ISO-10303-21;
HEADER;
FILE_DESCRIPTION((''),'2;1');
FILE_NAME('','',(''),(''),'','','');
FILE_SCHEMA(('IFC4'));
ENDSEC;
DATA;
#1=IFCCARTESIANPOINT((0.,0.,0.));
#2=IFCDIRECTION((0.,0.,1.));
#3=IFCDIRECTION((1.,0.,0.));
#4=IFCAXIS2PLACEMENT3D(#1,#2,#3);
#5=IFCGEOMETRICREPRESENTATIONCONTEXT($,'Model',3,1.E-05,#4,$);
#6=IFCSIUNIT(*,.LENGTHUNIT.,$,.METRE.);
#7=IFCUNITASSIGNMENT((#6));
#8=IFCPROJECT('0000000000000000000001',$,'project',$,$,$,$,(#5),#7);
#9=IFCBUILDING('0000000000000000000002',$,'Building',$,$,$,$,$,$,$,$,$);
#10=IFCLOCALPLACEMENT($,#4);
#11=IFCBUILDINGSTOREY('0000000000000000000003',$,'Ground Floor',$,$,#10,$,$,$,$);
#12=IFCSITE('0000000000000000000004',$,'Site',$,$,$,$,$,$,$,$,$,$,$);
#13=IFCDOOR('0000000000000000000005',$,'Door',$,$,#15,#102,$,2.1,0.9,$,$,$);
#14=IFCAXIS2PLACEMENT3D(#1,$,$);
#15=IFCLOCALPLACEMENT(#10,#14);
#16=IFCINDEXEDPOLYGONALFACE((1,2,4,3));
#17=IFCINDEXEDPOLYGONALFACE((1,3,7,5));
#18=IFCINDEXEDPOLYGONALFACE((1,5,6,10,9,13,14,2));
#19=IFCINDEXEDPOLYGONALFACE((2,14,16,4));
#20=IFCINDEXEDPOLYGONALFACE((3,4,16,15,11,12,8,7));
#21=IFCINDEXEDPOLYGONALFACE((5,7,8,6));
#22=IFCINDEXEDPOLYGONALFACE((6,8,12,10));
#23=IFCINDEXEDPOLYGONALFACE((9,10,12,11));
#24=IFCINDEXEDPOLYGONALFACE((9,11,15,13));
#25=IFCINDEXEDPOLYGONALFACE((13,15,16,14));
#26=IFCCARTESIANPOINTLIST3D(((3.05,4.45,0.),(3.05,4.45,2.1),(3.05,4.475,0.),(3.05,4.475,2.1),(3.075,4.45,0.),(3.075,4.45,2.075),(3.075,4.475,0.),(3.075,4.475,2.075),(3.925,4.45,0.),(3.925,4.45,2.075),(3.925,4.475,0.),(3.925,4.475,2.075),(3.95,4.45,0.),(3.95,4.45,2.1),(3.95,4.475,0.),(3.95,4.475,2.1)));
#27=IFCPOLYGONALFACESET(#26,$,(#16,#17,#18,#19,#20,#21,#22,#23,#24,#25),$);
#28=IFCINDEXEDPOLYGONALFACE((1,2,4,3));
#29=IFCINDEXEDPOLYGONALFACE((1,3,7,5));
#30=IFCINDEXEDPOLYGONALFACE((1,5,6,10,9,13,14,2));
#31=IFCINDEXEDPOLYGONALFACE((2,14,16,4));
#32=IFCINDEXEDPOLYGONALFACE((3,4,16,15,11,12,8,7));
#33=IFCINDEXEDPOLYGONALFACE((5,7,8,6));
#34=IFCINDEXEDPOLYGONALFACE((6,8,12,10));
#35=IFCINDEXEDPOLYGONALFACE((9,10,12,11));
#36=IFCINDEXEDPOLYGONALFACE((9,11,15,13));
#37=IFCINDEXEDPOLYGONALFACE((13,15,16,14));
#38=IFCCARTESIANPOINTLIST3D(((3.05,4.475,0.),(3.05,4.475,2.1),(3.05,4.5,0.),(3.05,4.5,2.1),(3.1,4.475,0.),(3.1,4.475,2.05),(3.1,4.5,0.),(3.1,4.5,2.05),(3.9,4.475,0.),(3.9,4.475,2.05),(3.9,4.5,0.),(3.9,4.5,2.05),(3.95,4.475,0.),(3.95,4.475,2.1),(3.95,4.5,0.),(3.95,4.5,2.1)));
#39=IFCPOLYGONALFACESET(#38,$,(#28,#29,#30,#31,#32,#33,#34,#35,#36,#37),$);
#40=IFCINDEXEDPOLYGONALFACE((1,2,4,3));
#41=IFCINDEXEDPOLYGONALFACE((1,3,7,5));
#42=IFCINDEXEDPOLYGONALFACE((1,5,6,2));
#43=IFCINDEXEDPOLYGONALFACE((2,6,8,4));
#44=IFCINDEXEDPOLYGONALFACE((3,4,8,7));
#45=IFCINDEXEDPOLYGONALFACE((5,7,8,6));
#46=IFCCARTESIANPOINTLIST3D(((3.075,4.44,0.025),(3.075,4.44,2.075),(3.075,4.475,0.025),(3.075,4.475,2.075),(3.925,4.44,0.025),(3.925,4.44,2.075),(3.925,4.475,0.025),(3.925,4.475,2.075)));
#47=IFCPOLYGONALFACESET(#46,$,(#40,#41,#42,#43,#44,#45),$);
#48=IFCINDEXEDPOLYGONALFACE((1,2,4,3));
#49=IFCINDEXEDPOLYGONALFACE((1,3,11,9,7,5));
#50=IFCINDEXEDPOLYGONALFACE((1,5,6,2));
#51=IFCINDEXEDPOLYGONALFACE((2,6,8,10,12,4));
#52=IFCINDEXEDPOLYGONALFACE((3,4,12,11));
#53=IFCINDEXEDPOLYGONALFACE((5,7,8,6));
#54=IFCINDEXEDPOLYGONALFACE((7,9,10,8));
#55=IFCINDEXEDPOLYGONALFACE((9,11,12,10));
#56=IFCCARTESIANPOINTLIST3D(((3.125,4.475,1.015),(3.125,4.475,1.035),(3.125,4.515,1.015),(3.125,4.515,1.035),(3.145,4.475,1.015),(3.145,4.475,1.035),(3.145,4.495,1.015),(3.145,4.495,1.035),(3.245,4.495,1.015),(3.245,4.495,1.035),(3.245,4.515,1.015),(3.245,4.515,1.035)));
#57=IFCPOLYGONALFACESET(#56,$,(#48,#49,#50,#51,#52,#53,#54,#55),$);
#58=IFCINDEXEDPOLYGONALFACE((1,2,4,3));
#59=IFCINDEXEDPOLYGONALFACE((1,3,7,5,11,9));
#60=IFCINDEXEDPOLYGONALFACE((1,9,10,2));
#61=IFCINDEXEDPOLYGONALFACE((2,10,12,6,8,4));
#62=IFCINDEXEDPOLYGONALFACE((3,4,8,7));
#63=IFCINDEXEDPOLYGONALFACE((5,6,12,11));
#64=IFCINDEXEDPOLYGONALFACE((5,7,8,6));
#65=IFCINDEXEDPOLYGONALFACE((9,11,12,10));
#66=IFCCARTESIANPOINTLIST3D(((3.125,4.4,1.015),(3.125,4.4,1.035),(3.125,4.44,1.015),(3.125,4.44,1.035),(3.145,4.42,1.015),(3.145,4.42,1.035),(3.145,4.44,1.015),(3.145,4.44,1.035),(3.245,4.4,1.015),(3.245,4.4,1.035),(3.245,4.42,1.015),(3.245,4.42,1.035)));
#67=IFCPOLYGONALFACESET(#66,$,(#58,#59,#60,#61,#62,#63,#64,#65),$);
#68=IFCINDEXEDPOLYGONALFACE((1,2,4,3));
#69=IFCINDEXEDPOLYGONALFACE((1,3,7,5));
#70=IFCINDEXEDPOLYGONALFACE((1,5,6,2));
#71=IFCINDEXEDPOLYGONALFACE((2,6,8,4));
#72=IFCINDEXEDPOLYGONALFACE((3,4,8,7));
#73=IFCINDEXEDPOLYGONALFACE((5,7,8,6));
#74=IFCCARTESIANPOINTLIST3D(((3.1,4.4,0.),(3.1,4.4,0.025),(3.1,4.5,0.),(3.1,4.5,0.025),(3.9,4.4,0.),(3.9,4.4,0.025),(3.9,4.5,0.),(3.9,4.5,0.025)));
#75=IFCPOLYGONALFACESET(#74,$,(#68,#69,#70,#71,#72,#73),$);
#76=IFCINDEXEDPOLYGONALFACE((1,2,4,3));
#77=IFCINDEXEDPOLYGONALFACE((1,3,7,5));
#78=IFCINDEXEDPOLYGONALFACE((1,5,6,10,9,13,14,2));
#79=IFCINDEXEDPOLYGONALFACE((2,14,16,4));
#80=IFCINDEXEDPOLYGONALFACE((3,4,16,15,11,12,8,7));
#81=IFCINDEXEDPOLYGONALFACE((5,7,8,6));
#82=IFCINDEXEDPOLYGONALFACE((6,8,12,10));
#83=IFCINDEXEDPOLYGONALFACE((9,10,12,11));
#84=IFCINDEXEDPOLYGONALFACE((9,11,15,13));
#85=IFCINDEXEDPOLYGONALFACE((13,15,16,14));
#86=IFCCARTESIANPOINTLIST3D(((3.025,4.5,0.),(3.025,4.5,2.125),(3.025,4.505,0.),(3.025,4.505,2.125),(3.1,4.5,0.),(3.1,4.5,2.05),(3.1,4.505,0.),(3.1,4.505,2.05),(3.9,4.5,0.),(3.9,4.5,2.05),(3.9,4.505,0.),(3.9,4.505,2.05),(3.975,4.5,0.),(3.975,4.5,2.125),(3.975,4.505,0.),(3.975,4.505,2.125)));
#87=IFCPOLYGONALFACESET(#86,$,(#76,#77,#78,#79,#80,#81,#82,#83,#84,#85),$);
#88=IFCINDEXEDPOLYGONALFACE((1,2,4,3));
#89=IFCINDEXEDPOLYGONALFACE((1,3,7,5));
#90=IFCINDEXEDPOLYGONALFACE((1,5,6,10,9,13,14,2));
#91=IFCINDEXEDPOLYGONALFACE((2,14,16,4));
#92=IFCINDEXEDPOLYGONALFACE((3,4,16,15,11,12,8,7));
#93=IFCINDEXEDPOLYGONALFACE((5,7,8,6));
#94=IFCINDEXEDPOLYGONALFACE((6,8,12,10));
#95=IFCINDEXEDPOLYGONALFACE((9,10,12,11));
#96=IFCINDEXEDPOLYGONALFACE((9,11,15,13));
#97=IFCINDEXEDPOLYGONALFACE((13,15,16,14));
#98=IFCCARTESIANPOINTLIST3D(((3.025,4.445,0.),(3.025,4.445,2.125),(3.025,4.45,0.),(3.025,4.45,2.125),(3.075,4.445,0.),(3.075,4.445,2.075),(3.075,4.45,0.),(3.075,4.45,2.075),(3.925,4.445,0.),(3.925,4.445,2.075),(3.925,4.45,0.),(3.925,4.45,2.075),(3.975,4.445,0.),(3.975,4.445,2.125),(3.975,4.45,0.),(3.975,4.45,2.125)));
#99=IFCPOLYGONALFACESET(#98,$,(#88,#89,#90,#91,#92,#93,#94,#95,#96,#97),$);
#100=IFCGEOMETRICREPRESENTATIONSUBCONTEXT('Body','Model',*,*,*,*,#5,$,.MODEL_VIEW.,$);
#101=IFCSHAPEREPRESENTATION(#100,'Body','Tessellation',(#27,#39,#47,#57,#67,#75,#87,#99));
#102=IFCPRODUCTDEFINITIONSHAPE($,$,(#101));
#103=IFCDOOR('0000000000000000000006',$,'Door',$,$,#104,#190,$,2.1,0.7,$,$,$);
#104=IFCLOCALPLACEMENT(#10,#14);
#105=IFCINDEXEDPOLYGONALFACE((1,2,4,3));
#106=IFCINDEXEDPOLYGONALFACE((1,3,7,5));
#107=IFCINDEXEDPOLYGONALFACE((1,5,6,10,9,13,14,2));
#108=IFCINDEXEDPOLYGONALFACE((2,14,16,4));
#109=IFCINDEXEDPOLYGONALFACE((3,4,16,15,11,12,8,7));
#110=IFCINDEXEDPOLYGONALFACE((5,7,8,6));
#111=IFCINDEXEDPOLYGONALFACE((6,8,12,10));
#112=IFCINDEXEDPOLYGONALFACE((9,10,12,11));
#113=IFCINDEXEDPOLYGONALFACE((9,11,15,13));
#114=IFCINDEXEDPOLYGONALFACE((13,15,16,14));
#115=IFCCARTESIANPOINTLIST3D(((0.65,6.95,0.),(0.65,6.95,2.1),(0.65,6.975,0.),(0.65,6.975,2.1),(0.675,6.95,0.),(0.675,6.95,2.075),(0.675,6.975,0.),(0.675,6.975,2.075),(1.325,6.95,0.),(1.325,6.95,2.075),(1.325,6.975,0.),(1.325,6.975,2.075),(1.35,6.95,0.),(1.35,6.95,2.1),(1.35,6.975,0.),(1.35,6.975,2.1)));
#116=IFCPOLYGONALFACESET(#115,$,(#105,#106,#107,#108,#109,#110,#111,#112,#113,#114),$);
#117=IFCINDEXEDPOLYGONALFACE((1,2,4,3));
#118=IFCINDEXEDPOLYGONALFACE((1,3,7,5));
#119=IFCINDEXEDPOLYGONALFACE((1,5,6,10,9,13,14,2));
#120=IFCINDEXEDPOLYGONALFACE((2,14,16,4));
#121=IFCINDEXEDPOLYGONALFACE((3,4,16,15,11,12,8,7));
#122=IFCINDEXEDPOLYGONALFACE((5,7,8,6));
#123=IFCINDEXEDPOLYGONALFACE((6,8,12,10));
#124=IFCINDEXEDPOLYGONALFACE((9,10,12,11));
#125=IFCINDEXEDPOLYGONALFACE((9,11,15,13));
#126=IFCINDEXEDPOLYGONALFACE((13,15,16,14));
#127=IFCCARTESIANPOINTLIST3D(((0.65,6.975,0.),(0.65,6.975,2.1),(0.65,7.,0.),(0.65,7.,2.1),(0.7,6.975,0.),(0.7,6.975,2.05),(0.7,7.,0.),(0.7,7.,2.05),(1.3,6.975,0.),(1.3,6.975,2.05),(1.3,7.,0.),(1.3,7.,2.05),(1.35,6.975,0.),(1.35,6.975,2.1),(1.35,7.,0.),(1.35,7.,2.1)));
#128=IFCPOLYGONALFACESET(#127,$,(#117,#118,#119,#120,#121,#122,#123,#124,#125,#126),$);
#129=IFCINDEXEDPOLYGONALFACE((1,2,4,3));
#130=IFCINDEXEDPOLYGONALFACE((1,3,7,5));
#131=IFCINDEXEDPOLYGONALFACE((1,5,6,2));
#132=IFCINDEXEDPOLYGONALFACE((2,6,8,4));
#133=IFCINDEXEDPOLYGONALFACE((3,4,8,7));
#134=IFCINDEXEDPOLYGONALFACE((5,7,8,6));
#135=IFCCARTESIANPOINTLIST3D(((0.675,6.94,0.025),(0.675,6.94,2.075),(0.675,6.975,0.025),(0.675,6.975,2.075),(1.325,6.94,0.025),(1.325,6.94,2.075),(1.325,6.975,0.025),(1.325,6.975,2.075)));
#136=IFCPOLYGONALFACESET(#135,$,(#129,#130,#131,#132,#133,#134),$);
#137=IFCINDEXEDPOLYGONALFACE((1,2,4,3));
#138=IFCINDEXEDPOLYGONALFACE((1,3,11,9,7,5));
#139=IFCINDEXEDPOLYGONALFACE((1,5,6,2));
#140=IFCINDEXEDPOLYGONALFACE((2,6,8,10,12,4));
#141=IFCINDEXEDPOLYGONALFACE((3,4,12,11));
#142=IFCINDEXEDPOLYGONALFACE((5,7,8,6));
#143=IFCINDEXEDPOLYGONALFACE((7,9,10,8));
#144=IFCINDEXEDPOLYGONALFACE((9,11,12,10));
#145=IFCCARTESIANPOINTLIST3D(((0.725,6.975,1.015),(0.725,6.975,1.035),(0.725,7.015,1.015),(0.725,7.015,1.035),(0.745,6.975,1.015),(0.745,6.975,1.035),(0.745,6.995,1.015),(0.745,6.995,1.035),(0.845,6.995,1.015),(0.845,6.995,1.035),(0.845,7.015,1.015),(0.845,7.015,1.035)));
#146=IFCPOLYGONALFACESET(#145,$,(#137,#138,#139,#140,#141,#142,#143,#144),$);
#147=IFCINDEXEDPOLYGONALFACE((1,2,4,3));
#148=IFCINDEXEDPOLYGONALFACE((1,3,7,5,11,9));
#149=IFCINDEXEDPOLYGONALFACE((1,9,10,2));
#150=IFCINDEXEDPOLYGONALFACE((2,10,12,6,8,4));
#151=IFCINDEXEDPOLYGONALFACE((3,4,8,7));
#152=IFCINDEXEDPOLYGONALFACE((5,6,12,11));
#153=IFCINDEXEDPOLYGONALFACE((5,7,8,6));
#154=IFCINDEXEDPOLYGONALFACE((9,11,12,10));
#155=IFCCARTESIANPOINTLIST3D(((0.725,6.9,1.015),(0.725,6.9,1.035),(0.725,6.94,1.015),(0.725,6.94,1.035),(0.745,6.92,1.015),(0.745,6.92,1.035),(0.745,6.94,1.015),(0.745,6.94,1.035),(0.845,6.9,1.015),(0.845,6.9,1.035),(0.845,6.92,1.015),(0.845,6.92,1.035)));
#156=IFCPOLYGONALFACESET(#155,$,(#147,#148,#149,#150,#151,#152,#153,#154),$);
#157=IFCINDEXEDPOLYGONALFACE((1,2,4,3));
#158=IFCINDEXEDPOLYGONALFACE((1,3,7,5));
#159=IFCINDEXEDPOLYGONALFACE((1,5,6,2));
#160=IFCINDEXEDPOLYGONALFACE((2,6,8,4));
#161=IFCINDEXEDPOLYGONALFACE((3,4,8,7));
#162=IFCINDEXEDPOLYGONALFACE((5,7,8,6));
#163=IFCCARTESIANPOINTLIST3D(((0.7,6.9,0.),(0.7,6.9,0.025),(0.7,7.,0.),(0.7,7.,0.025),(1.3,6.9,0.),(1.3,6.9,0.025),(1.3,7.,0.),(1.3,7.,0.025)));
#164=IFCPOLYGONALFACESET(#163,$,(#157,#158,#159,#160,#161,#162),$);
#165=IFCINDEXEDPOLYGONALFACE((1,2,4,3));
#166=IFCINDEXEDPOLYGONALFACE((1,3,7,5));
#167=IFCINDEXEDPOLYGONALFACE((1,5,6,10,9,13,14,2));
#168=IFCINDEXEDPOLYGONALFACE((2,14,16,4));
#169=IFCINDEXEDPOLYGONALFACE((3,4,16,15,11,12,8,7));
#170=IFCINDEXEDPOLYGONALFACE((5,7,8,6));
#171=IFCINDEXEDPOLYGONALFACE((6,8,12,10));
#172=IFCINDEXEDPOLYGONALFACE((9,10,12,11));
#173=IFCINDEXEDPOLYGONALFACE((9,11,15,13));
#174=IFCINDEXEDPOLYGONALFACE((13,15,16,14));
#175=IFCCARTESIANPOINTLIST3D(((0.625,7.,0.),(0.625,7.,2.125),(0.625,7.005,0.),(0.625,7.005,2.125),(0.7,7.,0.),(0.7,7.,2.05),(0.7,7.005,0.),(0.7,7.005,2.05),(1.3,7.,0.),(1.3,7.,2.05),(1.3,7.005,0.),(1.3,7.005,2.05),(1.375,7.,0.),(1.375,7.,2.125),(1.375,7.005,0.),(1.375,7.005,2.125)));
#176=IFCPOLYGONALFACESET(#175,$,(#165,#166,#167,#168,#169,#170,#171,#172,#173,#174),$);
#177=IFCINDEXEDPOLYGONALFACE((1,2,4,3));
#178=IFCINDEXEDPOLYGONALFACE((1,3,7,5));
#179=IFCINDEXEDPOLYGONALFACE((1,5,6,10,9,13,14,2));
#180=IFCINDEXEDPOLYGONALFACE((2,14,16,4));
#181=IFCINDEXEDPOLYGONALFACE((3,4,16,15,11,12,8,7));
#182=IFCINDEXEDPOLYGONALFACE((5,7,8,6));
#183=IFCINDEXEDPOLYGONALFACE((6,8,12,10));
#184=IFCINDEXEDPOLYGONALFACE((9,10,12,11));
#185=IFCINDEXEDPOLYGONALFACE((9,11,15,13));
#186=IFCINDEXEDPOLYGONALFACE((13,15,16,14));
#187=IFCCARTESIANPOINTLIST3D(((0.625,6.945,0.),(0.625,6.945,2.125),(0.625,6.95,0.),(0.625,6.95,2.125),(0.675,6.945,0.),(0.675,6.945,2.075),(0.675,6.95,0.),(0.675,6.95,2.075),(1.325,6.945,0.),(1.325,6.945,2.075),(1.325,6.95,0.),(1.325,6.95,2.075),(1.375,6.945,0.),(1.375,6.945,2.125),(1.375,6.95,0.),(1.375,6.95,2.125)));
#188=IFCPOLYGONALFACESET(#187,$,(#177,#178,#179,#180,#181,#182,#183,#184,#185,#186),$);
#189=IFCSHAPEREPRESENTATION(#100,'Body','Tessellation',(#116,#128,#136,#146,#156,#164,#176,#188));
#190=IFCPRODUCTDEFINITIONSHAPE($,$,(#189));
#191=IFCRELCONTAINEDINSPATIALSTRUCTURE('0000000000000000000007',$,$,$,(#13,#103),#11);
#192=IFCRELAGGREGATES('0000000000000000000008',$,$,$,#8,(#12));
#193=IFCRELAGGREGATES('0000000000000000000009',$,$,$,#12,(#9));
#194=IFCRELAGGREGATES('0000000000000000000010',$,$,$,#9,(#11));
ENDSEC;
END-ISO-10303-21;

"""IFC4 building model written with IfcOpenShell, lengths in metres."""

from ifc_helpers import new_model, si_unit, frame, origin_with_axes, place, context, subcontext, project, spatial, line, indexed_curve, outline, extrude, element, save


model = new_model("IFC4")

# Units and contexts
model_context = context("Model", 3, precision=1e-05, world=origin_with_axes())
body_context = subcontext(model_context, "Body", "Model", "MODEL_VIEW")
ifc_project = project(units=[si_unit("LENGTHUNIT", "METRE")], contexts=[model_context])

# Site, building, storey
site = spatial("IfcSite", under=ifc_project, Name="Site")
building = spatial("IfcBuilding", under=site, Name="Building")
storey_placement = place(None, origin_with_axes())
storey = spatial("IfcBuildingStorey", under=building, at=storey_placement, Name="Ground Floor")

# Doors
door_1_placement = place(storey_placement, frame((3.95, 4.5, 0.0), z_axis=(0.0, 0.0, 1.0), x_axis=(-1.0, 0.0, 0.0)))
element("IfcDoor", 1, at=door_1_placement, inside=storey, Name="Door", OverallHeight=2.1, OverallWidth=0.9, context=body_context, shape_type="SweptSolid", body=[
    extrude(outline(indexed_curve([(0.0, 0.0), (0.0, 2.1), (0.9, 2.1), (0.9, 0.0), (0.875, 0.0), (0.875, 2.075), (0.025, 2.075), (0.025, 0.0)], segments=[line(1, 2, 3, 4, 5, 6, 7, 8, 1)])), frame((0.0, 0.025, 0.0), z_axis=(0.0, -1.0, 0.0), x_axis=(1.0, 0.0, 0.0)), (0.0, 0.0, -1.0), 0.025),
    extrude(outline(indexed_curve([(0.0, 0.0), (0.0, 2.1), (0.9, 2.1), (0.9, 0.0), (0.85, 0.0), (0.85, 2.05), (0.05, 2.05), (0.05, 0.0)], segments=[line(1, 2, 3, 4, 5, 6, 7, 8, 1)])), frame((0.0, 0.0, 0.0), z_axis=(0.0, -1.0, 0.0), x_axis=(1.0, 0.0, 0.0)), (0.0, 0.0, -1.0), 0.025),
    extrude(outline(indexed_curve([(0.0, 0.0), (0.85, 0.0), (0.85, 0.035), (0.0, 0.035)], segments=[line(1, 2, 3, 4, 1)])), frame((0.025, 0.025, 0.025), z_axis=(0.0, 0.0, 1.0), x_axis=(1.0, 0.0, 0.0)), (0.0, 0.0, 1.0), 2.05),
    extrude(outline(indexed_curve([(0.0, 0.0), (0.0, -0.04), (-0.12, -0.04), (-0.12, -0.02), (-0.02, -0.02), (-0.02, 0.0)], segments=[line(1, 2, 3, 4, 5, 6, 1)])), frame((0.825, 0.025, 1.015), z_axis=(0.0, 0.0, 1.0), x_axis=(1.0, 0.0, 0.0)), (0.0, 0.0, 1.0), 0.02),
    extrude(outline(indexed_curve([(0.0, 0.0), (0.0, 0.04), (-0.12, 0.04), (-0.12, 0.02), (-0.02, 0.02), (-0.02, 0.0)], segments=[line(1, 2, 3, 4, 5, 6, 1)])), frame((0.825, 0.06, 1.015), z_axis=(0.0, 0.0, 1.0), x_axis=(1.0, 0.0, 0.0)), (0.0, 0.0, 1.0), 0.02),
    extrude(outline(indexed_curve([(0.0, 0.0), (0.8, 0.0), (0.8, 0.1), (0.0, 0.1)], segments=[line(1, 2, 3, 4, 1)])), frame((0.05, 0.0, 0.0), z_axis=(0.0, 0.0, 1.0), x_axis=(1.0, 0.0, 0.0)), (0.0, 0.0, 1.0), 0.025),
    extrude(outline(indexed_curve([(0.0, 0.0), (0.0, 2.125), (0.95, 2.125), (0.95, 0.0), (0.875, 0.0), (0.875, 2.05), (0.075, 2.05), (0.075, 0.0)], segments=[line(1, 2, 3, 4, 5, 6, 7, 8, 1)])), frame((-0.025, -0.005, 0.0), z_axis=(0.0, -1.0, 0.0), x_axis=(1.0, 0.0, 0.0)), (0.0, 0.0, -1.0), 0.005),
    extrude(outline(indexed_curve([(0.0, 0.0), (0.0, 2.125), (0.95, 2.125), (0.95, 0.0), (0.9, 0.0), (0.9, 2.075), (0.05, 2.075), (0.05, 0.0)], segments=[line(1, 2, 3, 4, 5, 6, 7, 8, 1)])), frame((-0.025, 0.05, 0.0), z_axis=(0.0, -1.0, 0.0), x_axis=(1.0, 0.0, 0.0)), (0.0, 0.0, -1.0), 0.005),
])
door_2_placement = place(storey_placement, frame((1.35, 7.0, 0.0), z_axis=(0.0, 0.0, 1.0), x_axis=(-1.0, 0.0, 0.0)))
element("IfcDoor", 2, at=door_2_placement, inside=storey, Name="Door", OverallHeight=2.1, OverallWidth=0.7, context=body_context, shape_type="SweptSolid", body=[
    extrude(outline(indexed_curve([(0.0, 0.0), (0.0, 2.1), (0.7, 2.1), (0.7, 0.0), (0.675, 0.0), (0.675, 2.075), (0.025, 2.075), (0.025, 0.0)], segments=[line(1, 2, 3, 4, 5, 6, 7, 8, 1)])), frame((0.0, 0.025, 0.0), z_axis=(0.0, -1.0, 0.0), x_axis=(1.0, 0.0, 0.0)), (0.0, 0.0, -1.0), 0.025),
    extrude(outline(indexed_curve([(0.0, 0.0), (0.0, 2.1), (0.7, 2.1), (0.7, 0.0), (0.65, 0.0), (0.65, 2.05), (0.05, 2.05), (0.05, 0.0)], segments=[line(1, 2, 3, 4, 5, 6, 7, 8, 1)])), frame((0.0, 0.0, 0.0), z_axis=(0.0, -1.0, 0.0), x_axis=(1.0, 0.0, 0.0)), (0.0, 0.0, -1.0), 0.025),
    extrude(outline(indexed_curve([(0.0, 0.0), (0.65, 0.0), (0.65, 0.035), (0.0, 0.035)], segments=[line(1, 2, 3, 4, 1)])), frame((0.025, 0.025, 0.025), z_axis=(0.0, 0.0, 1.0), x_axis=(1.0, 0.0, 0.0)), (0.0, 0.0, 1.0), 2.05),
    extrude(outline(indexed_curve([(0.0, 0.0), (0.0, -0.04), (-0.12, -0.04), (-0.12, -0.02), (-0.02, -0.02), (-0.02, 0.0)], segments=[line(1, 2, 3, 4, 5, 6, 1)])), frame((0.625, 0.025, 1.015), z_axis=(0.0, 0.0, 1.0), x_axis=(1.0, 0.0, 0.0)), (0.0, 0.0, 1.0), 0.02),
    extrude(outline(indexed_curve([(0.0, 0.0), (0.0, 0.04), (-0.12, 0.04), (-0.12, 0.02), (-0.02, 0.02), (-0.02, 0.0)], segments=[line(1, 2, 3, 4, 5, 6, 1)])), frame((0.625, 0.06, 1.015), z_axis=(0.0, 0.0, 1.0), x_axis=(1.0, 0.0, 0.0)), (0.0, 0.0, 1.0), 0.02),
    extrude(outline(indexed_curve([(0.0, 0.0), (0.6, 0.0), (0.6, 0.1), (0.0, 0.1)], segments=[line(1, 2, 3, 4, 1)])), frame((0.05, 0.0, 0.0), z_axis=(0.0, 0.0, 1.0), x_axis=(1.0, 0.0, 0.0)), (0.0, 0.0, 1.0), 0.025),
    extrude(outline(indexed_curve([(0.0, 0.0), (0.0, 2.125), (0.75, 2.125), (0.75, 0.0), (0.675, 0.0), (0.675, 2.05), (0.075, 2.05), (0.075, 0.0)], segments=[line(1, 2, 3, 4, 5, 6, 7, 8, 1)])), frame((-0.025, -0.005, 0.0), z_axis=(0.0, -1.0, 0.0), x_axis=(1.0, 0.0, 0.0)), (0.0, 0.0, -1.0), 0.005),
    extrude(outline(indexed_curve([(0.0, 0.0), (0.0, 2.125), (0.75, 2.125), (0.75, 0.0), (0.7, 0.0), (0.7, 2.075), (0.05, 2.075), (0.05, 0.0)], segments=[line(1, 2, 3, 4, 5, 6, 7, 8, 1)])), frame((-0.025, 0.05, 0.0), z_axis=(0.0, -1.0, 0.0), x_axis=(1.0, 0.0, 0.0)), (0.0, 0.0, -1.0), 0.005),
])

save(model, "model.ifc")
